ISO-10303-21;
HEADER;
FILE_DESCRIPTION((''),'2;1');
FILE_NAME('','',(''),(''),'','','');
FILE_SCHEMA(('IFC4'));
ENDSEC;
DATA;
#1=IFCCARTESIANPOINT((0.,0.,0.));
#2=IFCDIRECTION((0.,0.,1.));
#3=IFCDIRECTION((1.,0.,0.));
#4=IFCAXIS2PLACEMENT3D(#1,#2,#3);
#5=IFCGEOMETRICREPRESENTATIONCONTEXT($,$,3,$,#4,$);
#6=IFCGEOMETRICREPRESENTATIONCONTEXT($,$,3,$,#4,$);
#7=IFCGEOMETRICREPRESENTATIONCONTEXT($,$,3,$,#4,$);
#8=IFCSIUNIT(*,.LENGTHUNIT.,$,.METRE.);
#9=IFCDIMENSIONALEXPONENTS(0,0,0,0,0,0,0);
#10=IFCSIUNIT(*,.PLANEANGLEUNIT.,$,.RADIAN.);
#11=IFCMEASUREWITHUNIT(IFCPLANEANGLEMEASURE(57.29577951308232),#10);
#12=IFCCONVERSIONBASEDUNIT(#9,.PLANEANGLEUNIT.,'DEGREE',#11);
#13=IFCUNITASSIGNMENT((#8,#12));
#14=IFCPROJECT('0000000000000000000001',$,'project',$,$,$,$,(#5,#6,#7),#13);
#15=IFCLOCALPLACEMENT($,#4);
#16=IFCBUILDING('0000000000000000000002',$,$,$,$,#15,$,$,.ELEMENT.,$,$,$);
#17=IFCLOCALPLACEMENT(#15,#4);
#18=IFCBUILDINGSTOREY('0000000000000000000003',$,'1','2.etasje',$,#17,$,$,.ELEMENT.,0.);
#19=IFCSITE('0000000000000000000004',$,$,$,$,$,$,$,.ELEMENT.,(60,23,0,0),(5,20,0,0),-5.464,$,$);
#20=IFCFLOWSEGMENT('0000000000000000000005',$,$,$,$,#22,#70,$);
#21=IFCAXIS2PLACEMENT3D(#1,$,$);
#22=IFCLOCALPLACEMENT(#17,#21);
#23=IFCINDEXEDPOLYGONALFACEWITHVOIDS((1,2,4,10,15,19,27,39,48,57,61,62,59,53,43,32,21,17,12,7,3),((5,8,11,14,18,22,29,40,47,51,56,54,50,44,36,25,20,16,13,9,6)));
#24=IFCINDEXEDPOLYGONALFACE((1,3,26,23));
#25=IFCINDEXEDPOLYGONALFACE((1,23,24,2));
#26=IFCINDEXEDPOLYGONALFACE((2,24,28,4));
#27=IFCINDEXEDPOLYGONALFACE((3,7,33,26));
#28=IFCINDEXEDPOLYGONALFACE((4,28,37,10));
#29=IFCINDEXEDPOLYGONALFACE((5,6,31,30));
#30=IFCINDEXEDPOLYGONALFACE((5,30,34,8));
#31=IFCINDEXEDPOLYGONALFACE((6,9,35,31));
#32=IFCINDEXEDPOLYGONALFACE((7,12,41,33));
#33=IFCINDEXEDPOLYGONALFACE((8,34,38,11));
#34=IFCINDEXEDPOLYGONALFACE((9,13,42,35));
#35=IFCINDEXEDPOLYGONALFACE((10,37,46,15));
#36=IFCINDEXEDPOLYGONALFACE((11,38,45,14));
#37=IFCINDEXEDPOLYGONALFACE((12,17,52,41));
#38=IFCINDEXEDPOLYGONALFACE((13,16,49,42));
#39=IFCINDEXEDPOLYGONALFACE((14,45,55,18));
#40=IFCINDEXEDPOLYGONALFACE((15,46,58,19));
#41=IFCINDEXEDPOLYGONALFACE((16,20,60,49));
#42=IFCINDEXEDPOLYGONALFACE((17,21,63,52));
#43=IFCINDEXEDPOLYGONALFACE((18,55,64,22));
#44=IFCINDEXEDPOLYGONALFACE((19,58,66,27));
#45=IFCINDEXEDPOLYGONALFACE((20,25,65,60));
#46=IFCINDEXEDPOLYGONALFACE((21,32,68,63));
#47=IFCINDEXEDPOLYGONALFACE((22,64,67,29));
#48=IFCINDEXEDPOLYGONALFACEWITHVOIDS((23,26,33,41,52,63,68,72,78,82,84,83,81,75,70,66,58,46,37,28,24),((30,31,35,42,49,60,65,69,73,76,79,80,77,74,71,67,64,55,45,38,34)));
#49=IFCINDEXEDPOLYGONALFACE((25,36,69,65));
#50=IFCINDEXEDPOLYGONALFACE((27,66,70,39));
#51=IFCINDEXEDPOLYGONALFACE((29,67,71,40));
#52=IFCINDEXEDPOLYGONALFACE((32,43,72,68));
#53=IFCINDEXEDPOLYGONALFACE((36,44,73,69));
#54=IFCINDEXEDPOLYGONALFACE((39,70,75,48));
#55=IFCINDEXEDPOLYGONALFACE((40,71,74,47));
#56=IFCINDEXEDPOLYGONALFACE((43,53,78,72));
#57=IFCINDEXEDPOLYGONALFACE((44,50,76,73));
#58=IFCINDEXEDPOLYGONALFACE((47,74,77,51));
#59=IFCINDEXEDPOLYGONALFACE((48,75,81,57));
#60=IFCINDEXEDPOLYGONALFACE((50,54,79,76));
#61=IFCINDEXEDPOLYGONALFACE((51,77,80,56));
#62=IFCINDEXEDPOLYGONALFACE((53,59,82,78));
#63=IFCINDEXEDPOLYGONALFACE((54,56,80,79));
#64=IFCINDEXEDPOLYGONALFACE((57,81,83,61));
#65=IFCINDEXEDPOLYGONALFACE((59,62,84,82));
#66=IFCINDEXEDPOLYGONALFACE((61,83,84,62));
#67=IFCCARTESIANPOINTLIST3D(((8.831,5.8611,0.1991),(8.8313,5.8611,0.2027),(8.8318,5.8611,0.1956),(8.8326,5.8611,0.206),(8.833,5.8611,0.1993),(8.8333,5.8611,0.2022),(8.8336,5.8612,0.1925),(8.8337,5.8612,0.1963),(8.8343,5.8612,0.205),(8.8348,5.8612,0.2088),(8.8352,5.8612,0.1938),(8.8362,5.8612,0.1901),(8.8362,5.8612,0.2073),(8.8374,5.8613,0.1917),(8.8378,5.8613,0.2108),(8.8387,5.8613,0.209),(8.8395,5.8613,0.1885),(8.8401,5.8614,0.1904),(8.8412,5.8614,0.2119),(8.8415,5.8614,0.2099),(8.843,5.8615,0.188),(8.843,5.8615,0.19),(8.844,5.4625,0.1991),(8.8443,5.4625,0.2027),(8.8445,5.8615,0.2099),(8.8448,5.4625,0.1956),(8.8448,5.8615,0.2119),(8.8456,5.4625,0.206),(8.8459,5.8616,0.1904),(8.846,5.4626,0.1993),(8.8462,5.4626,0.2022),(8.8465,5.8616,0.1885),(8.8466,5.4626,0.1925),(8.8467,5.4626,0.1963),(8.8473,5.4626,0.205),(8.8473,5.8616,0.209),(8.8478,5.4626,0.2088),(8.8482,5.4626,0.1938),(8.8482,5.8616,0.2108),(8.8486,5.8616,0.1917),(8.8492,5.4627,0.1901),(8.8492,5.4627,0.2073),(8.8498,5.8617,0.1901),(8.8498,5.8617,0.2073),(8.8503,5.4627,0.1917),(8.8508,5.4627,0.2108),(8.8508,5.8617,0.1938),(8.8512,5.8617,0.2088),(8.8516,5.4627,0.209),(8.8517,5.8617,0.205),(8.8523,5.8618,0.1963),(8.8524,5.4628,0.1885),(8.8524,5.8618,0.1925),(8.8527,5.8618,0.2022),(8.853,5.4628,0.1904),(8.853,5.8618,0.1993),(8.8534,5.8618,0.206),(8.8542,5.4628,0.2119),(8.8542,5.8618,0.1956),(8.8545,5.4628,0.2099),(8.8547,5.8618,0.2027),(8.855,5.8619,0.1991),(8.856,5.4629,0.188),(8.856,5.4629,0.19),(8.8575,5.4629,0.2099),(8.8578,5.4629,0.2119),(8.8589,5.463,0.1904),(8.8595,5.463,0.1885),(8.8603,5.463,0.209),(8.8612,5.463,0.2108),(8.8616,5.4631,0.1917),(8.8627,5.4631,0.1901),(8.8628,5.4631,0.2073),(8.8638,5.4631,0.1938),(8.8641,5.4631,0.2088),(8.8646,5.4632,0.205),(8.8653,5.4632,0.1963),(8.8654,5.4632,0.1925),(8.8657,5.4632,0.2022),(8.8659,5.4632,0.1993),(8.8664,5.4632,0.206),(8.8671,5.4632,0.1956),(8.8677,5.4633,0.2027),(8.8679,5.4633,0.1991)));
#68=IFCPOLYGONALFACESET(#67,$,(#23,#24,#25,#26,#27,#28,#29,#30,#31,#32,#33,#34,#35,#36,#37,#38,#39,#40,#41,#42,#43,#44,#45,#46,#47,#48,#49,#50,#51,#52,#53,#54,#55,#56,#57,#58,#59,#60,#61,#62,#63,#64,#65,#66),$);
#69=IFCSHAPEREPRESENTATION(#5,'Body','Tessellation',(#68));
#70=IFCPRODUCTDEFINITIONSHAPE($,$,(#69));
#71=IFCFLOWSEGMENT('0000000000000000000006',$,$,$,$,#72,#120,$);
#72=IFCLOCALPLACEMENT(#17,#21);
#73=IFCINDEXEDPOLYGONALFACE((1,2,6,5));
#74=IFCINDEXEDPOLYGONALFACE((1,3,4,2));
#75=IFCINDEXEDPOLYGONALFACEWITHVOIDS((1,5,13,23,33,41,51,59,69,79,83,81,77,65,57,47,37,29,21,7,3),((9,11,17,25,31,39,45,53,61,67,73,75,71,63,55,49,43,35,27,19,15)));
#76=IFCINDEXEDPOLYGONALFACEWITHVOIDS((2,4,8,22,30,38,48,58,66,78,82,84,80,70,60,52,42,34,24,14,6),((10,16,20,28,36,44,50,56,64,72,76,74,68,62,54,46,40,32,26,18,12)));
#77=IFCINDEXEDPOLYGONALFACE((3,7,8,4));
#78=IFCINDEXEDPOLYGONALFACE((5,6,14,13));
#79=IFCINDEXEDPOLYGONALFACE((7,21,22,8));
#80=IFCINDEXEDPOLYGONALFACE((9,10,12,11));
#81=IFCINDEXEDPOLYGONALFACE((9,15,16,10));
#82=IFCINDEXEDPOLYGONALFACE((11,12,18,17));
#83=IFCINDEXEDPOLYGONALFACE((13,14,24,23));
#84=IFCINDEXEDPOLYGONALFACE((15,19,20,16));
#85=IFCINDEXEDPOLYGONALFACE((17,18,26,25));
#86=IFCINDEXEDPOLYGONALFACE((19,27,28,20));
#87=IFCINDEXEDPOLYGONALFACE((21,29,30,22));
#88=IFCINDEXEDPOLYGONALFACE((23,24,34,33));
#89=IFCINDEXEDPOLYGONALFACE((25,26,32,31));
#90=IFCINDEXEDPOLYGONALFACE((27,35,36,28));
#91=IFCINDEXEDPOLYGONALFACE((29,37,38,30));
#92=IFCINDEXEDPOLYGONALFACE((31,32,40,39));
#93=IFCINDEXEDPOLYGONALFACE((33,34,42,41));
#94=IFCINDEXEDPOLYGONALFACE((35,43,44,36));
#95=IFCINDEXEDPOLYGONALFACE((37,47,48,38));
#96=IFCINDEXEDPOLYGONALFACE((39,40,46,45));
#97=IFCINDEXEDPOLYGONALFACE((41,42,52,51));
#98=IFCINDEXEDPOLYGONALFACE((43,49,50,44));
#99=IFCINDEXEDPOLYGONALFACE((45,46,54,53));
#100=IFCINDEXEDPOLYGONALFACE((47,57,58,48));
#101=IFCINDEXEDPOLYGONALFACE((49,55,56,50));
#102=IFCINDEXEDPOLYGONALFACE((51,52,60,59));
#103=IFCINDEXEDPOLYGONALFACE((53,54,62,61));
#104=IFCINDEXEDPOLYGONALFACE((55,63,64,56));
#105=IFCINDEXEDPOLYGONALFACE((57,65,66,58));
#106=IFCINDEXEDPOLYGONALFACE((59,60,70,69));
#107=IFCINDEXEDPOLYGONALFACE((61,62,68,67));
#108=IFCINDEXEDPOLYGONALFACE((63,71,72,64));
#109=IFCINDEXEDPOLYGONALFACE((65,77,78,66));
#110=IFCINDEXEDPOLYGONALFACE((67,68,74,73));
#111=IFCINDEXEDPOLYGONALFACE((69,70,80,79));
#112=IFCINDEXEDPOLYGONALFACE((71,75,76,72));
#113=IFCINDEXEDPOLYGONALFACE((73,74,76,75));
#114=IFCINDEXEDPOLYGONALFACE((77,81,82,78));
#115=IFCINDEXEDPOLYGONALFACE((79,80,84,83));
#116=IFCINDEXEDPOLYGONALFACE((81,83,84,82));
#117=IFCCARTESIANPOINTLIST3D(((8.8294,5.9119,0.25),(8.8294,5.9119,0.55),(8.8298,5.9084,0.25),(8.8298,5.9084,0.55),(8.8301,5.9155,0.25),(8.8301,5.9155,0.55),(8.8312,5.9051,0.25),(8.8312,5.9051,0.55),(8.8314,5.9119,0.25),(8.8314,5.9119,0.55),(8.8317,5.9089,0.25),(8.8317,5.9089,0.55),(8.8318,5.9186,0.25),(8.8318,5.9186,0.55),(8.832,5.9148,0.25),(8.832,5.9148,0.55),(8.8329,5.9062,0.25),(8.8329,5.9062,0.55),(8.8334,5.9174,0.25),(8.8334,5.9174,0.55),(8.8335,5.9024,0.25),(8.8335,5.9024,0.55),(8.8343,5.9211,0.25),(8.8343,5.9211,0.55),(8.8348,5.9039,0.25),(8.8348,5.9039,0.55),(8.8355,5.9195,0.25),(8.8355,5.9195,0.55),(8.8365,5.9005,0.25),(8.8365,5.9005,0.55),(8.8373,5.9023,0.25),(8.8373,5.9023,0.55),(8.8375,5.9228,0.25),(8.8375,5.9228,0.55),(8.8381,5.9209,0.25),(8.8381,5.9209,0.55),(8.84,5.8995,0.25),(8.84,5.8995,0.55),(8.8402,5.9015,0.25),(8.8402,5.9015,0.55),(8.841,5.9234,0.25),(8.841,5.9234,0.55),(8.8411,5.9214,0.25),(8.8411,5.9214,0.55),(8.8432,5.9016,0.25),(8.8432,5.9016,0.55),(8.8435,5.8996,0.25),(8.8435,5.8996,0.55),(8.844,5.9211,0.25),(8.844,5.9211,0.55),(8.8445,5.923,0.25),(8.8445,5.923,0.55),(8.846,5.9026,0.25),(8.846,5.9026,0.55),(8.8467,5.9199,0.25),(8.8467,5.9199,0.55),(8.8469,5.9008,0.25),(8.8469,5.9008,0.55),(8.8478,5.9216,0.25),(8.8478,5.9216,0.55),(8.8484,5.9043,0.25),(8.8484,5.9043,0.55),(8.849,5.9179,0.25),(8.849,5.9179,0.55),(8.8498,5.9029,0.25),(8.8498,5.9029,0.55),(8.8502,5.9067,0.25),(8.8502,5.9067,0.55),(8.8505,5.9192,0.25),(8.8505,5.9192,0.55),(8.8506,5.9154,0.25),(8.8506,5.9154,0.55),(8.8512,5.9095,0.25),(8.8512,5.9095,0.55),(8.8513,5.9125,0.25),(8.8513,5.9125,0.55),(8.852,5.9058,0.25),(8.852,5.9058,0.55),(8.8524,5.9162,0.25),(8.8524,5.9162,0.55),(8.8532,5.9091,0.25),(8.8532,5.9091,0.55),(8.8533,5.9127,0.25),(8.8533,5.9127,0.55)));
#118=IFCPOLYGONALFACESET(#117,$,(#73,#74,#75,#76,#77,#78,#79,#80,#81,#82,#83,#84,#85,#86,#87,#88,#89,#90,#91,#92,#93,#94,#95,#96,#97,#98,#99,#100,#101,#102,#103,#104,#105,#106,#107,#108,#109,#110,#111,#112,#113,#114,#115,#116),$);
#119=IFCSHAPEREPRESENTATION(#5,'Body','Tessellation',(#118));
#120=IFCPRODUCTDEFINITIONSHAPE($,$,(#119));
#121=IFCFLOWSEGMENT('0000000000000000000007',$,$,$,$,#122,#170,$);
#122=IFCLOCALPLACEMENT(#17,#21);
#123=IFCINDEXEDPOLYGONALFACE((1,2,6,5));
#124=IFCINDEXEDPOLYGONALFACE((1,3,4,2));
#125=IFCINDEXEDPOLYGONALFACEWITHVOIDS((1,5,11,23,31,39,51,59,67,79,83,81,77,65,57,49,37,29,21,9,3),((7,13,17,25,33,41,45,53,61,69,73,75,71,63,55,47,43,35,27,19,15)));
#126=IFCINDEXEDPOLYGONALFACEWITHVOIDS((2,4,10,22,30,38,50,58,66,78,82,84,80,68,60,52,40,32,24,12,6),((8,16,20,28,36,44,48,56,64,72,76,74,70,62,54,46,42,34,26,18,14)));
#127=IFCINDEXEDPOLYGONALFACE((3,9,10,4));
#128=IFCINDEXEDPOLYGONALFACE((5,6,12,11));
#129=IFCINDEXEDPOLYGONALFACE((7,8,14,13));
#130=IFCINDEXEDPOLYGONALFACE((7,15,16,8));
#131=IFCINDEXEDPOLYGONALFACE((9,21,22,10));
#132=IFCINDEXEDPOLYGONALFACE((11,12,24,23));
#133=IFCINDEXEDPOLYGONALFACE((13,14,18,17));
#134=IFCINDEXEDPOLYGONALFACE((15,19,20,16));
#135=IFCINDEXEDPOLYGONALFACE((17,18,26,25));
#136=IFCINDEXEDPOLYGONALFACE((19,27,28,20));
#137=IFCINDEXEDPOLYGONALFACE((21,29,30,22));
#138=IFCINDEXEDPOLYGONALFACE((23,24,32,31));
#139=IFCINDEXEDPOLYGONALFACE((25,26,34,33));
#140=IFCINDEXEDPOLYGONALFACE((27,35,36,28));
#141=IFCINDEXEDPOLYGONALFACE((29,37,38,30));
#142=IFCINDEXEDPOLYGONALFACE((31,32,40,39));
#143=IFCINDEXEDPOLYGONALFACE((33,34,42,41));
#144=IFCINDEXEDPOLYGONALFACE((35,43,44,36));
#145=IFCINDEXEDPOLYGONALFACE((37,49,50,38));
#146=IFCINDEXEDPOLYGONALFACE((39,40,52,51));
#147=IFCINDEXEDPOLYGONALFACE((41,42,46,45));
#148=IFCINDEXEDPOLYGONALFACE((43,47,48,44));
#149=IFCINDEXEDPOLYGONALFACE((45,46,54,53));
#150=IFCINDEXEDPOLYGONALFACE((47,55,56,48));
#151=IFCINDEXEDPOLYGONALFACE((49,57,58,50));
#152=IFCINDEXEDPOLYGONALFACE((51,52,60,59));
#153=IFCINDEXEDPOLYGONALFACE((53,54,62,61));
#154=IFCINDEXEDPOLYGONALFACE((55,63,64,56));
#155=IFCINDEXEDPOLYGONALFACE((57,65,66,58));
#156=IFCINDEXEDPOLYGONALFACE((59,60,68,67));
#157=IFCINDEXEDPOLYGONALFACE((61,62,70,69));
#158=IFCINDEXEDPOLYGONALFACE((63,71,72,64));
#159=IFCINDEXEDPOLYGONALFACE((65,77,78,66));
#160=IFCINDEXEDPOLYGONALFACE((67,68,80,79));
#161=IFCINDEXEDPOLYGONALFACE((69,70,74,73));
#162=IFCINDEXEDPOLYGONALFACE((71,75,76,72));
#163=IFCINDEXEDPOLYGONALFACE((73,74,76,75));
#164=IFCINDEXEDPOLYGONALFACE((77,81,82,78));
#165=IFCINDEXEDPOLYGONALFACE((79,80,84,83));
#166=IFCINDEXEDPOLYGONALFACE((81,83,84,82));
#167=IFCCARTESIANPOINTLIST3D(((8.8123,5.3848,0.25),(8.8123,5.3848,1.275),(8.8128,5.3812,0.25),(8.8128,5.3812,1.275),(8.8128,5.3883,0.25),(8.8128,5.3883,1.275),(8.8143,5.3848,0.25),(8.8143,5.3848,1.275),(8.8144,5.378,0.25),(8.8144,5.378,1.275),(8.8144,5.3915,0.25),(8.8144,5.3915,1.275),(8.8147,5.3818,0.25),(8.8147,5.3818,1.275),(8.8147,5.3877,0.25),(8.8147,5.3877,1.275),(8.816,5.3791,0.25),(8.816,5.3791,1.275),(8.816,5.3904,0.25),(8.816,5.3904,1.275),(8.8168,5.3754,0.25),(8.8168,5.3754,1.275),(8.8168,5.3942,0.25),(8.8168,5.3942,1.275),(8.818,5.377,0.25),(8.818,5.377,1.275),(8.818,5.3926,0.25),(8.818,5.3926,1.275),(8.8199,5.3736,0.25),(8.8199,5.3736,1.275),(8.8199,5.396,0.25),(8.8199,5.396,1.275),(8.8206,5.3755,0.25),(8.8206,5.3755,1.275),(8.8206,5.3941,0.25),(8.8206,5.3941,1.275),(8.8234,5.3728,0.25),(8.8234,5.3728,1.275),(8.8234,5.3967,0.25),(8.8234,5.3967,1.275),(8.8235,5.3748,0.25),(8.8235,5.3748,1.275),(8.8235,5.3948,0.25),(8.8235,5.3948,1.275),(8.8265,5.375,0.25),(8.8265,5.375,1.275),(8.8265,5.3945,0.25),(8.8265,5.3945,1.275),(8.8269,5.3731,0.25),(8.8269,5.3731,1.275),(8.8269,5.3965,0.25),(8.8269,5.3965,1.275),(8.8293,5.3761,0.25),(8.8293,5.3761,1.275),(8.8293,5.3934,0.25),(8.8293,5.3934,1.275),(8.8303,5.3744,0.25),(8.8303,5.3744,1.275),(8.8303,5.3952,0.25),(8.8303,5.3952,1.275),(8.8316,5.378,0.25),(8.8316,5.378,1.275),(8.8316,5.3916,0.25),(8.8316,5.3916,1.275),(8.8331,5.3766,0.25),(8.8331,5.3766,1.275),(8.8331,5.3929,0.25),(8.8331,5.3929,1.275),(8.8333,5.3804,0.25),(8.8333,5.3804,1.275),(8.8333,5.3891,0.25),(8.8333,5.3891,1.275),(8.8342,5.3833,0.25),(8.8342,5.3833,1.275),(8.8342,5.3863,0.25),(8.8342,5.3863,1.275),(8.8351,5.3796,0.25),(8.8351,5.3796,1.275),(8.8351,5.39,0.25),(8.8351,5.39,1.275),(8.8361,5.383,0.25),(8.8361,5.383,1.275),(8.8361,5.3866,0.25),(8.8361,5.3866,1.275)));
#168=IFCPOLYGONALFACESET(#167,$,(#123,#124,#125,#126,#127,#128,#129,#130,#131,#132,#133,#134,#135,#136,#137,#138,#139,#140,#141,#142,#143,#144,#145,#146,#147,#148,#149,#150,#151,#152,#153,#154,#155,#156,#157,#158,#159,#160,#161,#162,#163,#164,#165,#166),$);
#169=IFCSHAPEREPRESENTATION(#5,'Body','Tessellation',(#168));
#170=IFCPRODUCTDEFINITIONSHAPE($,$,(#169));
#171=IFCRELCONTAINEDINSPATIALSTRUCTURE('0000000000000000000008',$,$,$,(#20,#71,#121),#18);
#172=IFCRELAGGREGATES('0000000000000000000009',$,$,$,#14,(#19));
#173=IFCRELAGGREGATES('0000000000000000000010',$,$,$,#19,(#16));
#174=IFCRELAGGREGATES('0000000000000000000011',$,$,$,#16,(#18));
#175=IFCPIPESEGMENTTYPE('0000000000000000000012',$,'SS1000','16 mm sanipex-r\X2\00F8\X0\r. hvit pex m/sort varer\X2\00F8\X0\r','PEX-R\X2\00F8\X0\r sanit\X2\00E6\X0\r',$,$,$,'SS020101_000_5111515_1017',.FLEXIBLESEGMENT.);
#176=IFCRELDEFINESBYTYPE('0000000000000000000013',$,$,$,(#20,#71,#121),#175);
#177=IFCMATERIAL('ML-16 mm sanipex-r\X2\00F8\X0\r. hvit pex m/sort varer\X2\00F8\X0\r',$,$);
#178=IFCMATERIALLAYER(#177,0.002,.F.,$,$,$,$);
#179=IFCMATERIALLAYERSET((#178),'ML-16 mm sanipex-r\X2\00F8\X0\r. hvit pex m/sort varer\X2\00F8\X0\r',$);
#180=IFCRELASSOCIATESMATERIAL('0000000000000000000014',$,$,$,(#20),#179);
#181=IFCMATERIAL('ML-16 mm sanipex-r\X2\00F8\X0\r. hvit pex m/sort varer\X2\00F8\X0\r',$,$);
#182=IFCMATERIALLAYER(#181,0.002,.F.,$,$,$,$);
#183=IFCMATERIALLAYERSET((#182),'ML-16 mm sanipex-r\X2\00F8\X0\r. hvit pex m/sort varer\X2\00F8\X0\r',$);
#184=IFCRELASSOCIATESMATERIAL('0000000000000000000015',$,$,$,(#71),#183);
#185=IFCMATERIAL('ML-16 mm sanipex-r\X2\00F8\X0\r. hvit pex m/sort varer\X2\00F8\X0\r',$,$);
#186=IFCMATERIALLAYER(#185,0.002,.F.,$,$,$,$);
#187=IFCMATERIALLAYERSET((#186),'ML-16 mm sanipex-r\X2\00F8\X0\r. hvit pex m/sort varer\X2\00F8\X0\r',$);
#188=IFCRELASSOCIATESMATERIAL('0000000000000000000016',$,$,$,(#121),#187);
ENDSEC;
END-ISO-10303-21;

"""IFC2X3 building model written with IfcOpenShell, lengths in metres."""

from ifc_helpers import new_model, entity, si_unit, converted_unit, frame, origin_with_axes, origin_2d_with_axis, place, context, project, spatial, hollow_circle, extrude, material, layer, layer_set, layer_usage, type_object, element, save


model = new_model("IFC2X3")

# Units and contexts
context_of_model_1 = context(None, 3, world=origin_with_axes())
context_of_model_2 = context(None, 3, world=origin_with_axes())
context_of_model_3 = context(None, 3, world=origin_with_axes())
ifc_project = project(units=[si_unit("LENGTHUNIT", "METRE"), converted_unit("PLANEANGLEUNIT", "DEGREE", entity("IfcPlaneAngleMeasure", 57.29577951308232), si_unit("PLANEANGLEUNIT", "RADIAN"), dimensions=[0, 0, 0, 0, 0, 0, 0])], contexts=[context_of_model_1, context_of_model_2, context_of_model_3])

# Site, building, storey
site = spatial("IfcSite", under=ifc_project, CompositionType="ELEMENT", RefLatitude=(60, 23, 0, 0), RefLongitude=(5, 20, 0, 0), RefElevation=-5.464)
building_placement = place(None, origin_with_axes())
building = spatial("IfcBuilding", under=site, at=building_placement, CompositionType="ELEMENT")
storey_placement = place(building_placement, origin_with_axes())
storey = spatial("IfcBuildingStorey", under=building, at=storey_placement, Name="1", Description="2.etasje", CompositionType="ELEMENT", Elevation=0.0)

# Flow segments
pipe_segment_type_1 = type_object("IfcPipeSegmentType", Name="SS1000", Description="16 mm sanipex-rør. hvit pex m/sort varerør", ApplicableOccurrence="PEX-Rør sanitær", ElementType="SS020101_000_5111515_1017", PredefinedType="FLEXIBLESEGMENT")
ifc_material_1 = material(Name="ML-16 mm sanipex-rør. hvit pex m/sort varerør")
ifc_layer_1 = layer(ifc_material_1, 0.002, ventilated=False)
ifc_layer_set_1 = layer_set([ifc_layer_1], Name="ML-16 mm sanipex-rør. hvit pex m/sort varerør")
ifc_layer_usage_1 = layer_usage(ifc_layer_set_1, "AXIS2", "POSITIVE", 0.0)
flow_segment_1_placement = place(storey_placement, frame((8.856, 5.4629, 0.2), z_axis=(-0.032532, 0.999471, 0.0), x_axis=(0.0, 0.0, -1.0)))
element("IfcFlowSegment", 1, at=flow_segment_1_placement, inside=storey, type_object=pipe_segment_type_1, material=ifc_layer_usage_1, context=context_of_model_1, shape_type="SweptSolid", body=[
    extrude(hollow_circle(Radius=0.012, WallThickness=0.002, at=origin_2d_with_axis()), origin_with_axes(), (0.0, 0.0, 1.0), 0.3988),
])
ifc_material_2 = material(Name="ML-16 mm sanipex-rør. hvit pex m/sort varerør")
ifc_layer_2 = layer(ifc_material_2, 0.002, ventilated=False)
ifc_layer_set_2 = layer_set([ifc_layer_2], Name="ML-16 mm sanipex-rør. hvit pex m/sort varerør")
ifc_layer_usage_2 = layer_usage(ifc_layer_set_2, "AXIS2", "POSITIVE", 0.0)
flow_segment_2_placement = place(storey_placement, frame((8.8414, 5.9114, 0.25), z_axis=(0.0, 0.0, 1.0), x_axis=(-0.032532, 0.999471, 0.0)))
element("IfcFlowSegment", 2, at=flow_segment_2_placement, inside=storey, type_object=pipe_segment_type_1, material=ifc_layer_usage_2, context=context_of_model_1, shape_type="SweptSolid", body=[
    extrude(hollow_circle(Radius=0.012, WallThickness=0.002, at=origin_2d_with_axis()), origin_with_axes(), (0.0, 0.0, 1.0), 0.3),
])
ifc_material_3 = material(Name="ML-16 mm sanipex-rør. hvit pex m/sort varerør")
ifc_layer_3 = layer(ifc_material_3, 0.002, ventilated=False)
ifc_layer_set_3 = layer_set([ifc_layer_3], Name="ML-16 mm sanipex-rør. hvit pex m/sort varerør")
ifc_layer_usage_3 = layer_usage(ifc_layer_set_3, "AXIS2", "POSITIVE", 0.0)
flow_segment_3_placement = place(storey_placement, frame((8.8243, 5.3848, 1.275), z_axis=(0.0, 0.0, -1.0), x_axis=(-1.0, 0.0, 0.0)))
element("IfcFlowSegment", 3, at=flow_segment_3_placement, inside=storey, type_object=pipe_segment_type_1, material=ifc_layer_usage_3, context=context_of_model_1, shape_type="SweptSolid", body=[
    extrude(hollow_circle(Radius=0.012, WallThickness=0.002, at=origin_2d_with_axis()), origin_with_axes(), (0.0, 0.0, 1.0), 1.025),
])

save(model, "model.ifc")
